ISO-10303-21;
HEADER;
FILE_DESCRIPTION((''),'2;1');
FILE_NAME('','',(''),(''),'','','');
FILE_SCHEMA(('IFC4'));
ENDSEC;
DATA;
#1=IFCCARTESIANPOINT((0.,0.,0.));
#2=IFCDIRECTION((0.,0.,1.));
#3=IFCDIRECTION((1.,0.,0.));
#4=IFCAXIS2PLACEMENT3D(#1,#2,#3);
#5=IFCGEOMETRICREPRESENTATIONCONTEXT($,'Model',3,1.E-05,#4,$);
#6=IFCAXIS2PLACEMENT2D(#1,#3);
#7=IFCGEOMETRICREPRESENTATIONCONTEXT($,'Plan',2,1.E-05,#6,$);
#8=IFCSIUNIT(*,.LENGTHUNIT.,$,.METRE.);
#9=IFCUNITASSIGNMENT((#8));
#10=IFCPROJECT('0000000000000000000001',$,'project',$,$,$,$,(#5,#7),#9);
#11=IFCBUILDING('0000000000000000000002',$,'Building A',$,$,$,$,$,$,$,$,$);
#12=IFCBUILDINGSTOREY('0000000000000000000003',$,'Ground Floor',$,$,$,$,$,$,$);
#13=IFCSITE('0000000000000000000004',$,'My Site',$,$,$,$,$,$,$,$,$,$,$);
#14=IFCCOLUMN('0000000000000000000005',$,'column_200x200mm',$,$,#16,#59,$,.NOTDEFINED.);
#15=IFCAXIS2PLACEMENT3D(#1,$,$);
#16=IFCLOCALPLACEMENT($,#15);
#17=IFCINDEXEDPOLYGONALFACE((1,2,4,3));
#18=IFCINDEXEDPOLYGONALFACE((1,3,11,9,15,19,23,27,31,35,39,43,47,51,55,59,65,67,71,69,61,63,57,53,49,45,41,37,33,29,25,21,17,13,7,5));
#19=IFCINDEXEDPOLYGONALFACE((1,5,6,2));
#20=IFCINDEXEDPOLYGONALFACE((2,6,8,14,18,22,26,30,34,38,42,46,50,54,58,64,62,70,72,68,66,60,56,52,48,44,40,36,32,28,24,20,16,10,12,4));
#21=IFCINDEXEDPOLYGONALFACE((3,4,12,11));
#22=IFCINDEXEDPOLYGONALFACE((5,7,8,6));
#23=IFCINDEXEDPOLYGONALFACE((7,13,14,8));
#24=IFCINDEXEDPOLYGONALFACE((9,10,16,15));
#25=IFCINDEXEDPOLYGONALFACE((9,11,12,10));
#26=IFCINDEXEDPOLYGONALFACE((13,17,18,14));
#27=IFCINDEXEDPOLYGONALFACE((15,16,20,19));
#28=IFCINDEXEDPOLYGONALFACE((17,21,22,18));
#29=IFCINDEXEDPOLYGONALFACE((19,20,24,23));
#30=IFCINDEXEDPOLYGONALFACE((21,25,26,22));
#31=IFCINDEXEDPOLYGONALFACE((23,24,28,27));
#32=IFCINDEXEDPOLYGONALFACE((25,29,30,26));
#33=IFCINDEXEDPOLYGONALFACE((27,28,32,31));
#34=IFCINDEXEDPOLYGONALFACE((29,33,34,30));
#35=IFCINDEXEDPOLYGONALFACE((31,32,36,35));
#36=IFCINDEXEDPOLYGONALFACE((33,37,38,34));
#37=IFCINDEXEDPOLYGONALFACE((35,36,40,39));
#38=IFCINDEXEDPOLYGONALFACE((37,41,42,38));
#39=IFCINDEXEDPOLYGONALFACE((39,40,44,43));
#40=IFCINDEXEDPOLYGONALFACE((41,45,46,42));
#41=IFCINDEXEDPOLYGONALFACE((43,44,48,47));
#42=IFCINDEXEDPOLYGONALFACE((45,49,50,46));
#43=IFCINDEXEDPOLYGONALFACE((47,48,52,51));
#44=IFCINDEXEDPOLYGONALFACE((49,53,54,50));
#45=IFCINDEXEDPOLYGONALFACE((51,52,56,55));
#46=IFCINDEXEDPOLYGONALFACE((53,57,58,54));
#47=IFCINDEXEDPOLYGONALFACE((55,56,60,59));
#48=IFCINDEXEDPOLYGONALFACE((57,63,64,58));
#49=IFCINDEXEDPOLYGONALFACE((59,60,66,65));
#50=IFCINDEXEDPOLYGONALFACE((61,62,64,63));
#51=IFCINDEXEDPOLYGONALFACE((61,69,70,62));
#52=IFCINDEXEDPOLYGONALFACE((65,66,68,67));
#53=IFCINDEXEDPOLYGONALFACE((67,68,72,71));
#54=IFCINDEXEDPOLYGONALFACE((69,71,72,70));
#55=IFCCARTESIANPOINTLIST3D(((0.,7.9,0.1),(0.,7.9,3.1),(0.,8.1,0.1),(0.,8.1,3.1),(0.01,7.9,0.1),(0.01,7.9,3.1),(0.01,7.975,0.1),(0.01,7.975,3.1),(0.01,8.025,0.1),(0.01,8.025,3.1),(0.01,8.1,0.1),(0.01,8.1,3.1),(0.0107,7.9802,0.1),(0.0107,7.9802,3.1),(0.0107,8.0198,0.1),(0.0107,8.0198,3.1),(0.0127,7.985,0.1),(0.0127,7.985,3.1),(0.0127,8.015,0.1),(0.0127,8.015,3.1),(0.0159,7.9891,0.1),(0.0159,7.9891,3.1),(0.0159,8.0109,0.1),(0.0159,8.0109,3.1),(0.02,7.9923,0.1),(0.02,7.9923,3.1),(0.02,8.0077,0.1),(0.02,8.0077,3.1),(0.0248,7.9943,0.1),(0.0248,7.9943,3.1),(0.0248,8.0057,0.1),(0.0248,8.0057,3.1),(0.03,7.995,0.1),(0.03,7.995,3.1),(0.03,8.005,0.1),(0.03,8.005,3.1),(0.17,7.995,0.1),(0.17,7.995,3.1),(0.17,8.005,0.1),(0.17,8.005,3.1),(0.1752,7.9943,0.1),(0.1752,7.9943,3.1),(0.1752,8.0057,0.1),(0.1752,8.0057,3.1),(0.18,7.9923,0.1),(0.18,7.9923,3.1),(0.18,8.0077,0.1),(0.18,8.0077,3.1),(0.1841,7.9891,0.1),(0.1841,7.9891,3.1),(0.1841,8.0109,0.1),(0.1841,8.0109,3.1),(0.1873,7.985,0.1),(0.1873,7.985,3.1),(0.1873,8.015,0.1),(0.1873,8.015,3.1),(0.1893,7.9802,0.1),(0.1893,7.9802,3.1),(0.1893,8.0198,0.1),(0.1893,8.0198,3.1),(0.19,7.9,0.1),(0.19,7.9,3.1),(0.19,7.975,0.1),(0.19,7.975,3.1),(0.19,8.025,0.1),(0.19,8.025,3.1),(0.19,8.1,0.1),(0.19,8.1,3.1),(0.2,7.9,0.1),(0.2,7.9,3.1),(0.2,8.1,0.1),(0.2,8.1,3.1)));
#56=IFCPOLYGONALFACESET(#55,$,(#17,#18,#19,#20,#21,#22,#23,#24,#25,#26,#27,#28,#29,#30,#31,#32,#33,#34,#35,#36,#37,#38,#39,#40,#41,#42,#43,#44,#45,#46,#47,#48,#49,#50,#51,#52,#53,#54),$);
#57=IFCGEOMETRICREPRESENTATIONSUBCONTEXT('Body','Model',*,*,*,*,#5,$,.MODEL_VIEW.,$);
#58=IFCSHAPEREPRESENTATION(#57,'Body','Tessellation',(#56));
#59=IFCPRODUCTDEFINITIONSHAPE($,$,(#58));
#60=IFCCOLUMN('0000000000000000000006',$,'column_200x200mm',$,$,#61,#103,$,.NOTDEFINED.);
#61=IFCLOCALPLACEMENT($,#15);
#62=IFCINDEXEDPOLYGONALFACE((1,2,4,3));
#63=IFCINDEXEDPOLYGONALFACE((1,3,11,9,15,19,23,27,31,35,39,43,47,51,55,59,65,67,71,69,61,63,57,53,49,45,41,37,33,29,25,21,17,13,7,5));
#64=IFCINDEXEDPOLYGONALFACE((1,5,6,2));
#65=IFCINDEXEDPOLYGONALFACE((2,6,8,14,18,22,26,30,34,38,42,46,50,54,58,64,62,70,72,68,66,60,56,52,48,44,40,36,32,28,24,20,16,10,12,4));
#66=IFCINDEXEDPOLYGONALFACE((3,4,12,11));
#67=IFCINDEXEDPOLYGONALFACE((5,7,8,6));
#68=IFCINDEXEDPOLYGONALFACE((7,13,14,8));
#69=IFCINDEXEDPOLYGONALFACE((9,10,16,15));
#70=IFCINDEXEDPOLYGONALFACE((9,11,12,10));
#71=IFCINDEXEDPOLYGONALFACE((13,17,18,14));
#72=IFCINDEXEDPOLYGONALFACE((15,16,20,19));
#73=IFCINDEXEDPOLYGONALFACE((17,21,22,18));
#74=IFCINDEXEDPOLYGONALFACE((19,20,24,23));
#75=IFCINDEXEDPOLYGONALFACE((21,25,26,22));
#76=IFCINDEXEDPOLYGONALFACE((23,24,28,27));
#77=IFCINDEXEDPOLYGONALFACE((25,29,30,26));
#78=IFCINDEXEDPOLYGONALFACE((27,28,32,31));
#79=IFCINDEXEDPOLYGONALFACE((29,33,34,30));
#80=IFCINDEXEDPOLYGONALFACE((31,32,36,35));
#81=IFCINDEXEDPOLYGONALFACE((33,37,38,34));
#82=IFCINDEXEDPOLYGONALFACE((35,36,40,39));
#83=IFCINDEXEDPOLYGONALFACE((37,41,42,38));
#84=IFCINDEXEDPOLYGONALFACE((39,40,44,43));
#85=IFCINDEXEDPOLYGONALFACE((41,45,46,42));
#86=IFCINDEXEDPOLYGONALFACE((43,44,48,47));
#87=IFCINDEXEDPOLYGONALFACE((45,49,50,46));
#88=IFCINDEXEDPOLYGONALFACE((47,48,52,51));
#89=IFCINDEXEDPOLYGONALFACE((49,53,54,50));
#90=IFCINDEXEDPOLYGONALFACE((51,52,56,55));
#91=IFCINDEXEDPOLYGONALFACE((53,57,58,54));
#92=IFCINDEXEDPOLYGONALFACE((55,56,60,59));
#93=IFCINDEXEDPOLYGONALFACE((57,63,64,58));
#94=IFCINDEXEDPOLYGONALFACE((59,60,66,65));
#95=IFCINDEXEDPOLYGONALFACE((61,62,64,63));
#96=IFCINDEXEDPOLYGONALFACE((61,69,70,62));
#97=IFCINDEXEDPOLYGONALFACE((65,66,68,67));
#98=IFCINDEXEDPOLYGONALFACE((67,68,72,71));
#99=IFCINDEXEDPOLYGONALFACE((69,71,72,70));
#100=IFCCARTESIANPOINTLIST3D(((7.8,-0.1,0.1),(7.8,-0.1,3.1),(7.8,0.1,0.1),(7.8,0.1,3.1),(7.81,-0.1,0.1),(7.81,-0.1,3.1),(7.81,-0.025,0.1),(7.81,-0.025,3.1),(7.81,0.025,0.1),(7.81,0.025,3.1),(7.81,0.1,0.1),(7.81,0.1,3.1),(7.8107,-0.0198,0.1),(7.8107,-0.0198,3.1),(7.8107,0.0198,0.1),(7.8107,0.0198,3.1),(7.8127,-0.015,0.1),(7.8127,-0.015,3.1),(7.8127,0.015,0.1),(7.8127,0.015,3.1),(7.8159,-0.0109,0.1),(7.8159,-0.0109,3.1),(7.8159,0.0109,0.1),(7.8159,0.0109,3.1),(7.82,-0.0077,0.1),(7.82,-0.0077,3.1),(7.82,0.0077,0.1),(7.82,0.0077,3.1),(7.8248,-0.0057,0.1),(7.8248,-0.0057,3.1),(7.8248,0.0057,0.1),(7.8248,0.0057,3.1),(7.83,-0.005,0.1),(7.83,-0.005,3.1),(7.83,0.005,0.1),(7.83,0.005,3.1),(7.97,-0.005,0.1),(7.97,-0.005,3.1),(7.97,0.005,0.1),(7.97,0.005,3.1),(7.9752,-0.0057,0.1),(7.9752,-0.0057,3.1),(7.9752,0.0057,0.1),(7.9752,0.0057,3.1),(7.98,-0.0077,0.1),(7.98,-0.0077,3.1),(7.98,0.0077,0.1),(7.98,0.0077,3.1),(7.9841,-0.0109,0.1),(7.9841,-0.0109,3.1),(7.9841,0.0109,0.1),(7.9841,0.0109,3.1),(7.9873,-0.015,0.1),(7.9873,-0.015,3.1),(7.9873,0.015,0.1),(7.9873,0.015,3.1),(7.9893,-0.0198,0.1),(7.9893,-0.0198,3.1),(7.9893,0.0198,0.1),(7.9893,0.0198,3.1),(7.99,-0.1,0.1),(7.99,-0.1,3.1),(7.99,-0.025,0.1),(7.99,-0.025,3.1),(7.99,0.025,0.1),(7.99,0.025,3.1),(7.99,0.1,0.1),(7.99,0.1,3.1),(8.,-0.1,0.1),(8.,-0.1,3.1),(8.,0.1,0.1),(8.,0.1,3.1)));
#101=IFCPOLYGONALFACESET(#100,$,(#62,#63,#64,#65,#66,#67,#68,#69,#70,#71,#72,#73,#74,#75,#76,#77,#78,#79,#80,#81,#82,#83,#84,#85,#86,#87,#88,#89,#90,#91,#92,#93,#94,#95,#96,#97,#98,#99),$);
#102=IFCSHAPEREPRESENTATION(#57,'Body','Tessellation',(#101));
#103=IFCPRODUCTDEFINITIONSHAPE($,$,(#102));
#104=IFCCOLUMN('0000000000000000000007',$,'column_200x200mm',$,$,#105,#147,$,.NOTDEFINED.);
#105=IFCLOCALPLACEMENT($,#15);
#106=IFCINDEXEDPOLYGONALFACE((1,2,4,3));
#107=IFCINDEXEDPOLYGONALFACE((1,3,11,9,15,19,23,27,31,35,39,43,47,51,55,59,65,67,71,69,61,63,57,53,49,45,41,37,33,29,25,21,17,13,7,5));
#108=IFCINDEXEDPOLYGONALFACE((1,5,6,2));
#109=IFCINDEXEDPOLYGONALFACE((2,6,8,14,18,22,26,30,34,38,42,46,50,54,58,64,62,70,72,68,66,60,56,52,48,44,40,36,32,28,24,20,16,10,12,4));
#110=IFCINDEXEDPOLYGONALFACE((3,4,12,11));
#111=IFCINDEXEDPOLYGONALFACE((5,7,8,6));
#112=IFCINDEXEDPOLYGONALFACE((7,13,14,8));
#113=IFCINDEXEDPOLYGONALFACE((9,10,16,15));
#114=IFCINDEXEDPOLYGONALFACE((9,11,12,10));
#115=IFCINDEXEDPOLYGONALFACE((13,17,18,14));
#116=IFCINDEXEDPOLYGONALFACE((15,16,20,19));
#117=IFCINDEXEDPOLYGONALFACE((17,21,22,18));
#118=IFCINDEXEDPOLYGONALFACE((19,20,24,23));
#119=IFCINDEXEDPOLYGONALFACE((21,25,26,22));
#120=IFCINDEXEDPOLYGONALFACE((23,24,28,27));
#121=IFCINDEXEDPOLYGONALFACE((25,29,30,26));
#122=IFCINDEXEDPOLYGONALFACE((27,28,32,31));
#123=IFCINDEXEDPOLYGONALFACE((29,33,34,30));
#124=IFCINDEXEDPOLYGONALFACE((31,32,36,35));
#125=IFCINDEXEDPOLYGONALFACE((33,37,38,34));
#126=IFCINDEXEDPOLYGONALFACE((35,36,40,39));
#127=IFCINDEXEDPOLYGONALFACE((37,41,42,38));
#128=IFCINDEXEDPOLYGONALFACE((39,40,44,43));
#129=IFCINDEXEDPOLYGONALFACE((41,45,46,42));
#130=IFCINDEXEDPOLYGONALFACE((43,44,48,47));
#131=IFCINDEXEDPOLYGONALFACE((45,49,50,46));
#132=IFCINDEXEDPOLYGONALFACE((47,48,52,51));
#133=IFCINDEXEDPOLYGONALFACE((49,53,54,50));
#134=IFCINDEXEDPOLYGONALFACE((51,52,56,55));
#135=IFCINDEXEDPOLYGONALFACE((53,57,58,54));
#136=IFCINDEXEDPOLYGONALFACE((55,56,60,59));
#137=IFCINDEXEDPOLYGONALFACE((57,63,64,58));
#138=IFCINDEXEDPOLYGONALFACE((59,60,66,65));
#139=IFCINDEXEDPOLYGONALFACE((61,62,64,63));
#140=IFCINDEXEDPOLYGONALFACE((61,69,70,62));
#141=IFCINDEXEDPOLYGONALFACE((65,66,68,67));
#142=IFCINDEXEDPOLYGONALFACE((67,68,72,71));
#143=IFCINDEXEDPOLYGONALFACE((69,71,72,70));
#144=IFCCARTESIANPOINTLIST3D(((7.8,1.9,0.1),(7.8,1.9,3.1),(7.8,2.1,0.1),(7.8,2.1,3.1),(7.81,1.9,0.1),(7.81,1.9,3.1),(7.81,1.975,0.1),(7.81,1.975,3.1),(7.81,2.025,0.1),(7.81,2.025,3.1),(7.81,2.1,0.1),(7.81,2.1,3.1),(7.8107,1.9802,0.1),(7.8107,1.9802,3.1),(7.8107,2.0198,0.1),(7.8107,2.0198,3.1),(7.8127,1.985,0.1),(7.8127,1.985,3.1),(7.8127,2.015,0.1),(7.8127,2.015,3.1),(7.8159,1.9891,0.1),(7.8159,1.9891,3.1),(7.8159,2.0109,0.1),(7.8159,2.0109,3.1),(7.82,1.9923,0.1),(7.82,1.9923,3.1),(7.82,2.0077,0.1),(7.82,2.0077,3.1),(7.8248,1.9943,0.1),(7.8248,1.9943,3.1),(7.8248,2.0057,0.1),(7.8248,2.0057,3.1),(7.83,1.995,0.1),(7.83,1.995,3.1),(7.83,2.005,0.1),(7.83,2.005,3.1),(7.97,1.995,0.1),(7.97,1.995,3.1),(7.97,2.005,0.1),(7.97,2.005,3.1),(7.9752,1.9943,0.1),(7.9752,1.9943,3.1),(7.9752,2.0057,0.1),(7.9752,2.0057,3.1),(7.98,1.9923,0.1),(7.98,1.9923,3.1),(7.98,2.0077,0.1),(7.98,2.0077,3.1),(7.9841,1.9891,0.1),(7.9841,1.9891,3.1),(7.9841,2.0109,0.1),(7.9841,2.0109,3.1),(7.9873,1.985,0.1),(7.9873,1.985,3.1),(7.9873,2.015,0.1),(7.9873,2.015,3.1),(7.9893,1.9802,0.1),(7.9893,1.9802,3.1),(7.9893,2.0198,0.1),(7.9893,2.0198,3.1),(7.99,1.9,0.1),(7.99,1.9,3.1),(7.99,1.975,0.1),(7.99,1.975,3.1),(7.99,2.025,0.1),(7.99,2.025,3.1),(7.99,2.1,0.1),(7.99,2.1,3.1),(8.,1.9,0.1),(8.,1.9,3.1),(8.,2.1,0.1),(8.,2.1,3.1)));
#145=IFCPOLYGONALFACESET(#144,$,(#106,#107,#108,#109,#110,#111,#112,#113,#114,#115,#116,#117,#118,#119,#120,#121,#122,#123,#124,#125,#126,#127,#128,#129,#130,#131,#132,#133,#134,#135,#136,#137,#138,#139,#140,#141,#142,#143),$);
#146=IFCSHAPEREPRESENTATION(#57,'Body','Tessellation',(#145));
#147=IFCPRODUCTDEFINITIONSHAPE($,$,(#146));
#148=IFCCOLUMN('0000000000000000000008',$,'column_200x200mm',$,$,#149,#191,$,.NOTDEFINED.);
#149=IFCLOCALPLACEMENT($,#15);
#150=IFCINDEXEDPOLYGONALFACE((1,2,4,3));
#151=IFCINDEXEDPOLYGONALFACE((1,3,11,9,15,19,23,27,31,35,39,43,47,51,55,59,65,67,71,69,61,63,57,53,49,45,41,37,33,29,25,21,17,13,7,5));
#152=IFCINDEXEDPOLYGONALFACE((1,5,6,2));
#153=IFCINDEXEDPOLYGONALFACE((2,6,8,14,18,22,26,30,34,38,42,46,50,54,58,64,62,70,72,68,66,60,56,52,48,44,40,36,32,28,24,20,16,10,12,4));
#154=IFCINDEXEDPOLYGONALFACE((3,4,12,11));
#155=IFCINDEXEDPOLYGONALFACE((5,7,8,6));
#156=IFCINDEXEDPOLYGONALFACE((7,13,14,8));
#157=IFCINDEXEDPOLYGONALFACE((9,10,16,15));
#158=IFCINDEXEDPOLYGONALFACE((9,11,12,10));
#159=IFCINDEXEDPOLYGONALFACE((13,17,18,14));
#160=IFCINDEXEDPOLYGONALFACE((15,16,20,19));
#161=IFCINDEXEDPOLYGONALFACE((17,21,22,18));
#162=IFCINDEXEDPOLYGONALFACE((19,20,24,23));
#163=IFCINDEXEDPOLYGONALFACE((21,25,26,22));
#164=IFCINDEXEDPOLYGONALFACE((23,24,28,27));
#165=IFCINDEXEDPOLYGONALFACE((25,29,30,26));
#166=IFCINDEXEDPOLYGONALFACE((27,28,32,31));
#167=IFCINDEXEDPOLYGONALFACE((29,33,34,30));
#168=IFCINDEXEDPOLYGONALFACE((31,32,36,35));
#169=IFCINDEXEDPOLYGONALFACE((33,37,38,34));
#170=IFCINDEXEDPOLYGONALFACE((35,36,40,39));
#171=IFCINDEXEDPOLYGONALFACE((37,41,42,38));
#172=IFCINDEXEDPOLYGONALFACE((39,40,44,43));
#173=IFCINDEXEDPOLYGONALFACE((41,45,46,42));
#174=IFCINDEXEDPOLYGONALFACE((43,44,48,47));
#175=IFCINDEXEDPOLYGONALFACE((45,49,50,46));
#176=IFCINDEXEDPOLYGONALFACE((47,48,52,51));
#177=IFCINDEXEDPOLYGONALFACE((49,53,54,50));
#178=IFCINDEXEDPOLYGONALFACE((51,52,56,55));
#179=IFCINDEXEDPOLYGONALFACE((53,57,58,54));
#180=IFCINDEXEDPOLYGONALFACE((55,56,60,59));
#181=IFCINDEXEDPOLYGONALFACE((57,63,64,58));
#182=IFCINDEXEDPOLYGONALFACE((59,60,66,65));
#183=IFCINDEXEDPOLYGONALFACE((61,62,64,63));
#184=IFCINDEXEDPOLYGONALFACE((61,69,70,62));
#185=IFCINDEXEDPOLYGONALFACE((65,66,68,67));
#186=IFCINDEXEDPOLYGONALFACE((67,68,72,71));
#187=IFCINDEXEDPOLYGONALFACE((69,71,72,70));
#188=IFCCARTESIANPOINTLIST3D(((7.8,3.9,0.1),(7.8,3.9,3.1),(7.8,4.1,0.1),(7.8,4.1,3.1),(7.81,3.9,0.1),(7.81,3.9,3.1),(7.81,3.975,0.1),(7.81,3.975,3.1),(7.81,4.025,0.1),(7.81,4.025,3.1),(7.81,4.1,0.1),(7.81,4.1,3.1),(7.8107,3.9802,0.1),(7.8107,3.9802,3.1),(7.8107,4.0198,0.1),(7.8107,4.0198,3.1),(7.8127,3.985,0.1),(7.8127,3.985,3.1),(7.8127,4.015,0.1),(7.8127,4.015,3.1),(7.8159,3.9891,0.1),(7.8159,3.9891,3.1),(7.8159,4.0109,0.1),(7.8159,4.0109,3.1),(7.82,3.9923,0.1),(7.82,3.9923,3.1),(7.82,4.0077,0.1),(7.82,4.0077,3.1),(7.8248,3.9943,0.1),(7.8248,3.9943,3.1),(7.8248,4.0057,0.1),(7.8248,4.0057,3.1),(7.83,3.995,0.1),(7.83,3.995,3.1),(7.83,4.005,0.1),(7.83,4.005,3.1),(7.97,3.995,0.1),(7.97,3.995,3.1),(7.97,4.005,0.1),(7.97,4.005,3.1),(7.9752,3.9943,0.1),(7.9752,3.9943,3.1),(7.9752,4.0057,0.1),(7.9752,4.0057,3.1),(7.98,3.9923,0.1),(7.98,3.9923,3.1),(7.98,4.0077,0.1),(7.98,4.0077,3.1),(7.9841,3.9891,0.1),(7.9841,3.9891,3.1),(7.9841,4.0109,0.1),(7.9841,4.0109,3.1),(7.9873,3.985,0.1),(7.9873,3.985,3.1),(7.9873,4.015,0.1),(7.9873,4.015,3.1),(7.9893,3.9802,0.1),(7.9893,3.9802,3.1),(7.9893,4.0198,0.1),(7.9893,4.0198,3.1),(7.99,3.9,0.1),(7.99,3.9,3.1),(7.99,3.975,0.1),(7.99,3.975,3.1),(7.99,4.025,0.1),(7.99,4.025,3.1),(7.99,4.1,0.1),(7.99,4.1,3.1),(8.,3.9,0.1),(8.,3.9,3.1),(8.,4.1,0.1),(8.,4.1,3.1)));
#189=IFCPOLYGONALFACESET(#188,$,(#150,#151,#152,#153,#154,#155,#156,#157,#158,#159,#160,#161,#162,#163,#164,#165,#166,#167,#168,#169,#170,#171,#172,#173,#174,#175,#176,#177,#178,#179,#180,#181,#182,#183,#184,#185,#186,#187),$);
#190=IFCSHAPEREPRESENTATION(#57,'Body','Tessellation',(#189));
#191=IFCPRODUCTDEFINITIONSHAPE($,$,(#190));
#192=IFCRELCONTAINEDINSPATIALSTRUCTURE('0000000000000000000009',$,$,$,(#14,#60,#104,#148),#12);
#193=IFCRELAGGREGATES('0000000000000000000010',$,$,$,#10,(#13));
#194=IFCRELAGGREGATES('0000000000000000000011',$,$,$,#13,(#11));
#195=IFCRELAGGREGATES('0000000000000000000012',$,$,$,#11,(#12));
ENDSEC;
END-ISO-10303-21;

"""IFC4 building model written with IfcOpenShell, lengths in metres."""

from ifc_helpers import new_model, entity, si_unit, frame, frame_2d, origin_with_axes, place, context, subcontext, project, spatial, extrude, element, save


model = new_model("IFC4")

# Units and contexts
model_context = context("Model", 3, precision=1e-05, world=origin_with_axes())
plan_context = context("Plan", 2, precision=1e-05, world=frame_2d((0.0, 0.0, 0.0), x_axis=(1.0, 0.0, 0.0)))
body_context = subcontext(model_context, "Body", "Model", "MODEL_VIEW")
ifc_project = project(units=[si_unit("LENGTHUNIT", "METRE")], contexts=[model_context, plan_context])

# Site, building, storey
site = spatial("IfcSite", under=ifc_project, Name="My Site")
building = spatial("IfcBuilding", under=site, Name="Building A")
storey = spatial("IfcBuildingStorey", under=building, Name="Ground Floor")

# Columns
for number, where, z_axis, x_axis, name in (
    (1, (0.1, 8.0, 0.1), (0.0, 0.0, 1.0), (0.0, 1.0, 0.0), "column_200x200mm"),
    (2, (7.9, 0.0, 0.1), (0.0, 0.0, 1.0), (0.0, 1.0, 0.0), "column_200x200mm"),
    (3, (7.9, 2.0, 0.1), (0.0, 0.0, 1.0), (0.0, 1.0, 0.0), "column_200x200mm"),
    (4, (7.9, 4.0, 0.1), (0.0, 0.0, 1.0), (0.0, 1.0, 0.0), "column_200x200mm"),
):
    element("IfcColumn", number, at=place(None, frame(where, z_axis=z_axis, x_axis=x_axis)), inside=storey, Name=name, PredefinedType="NOTDEFINED", context=body_context, shape_type="SweptSolid", body=[
        extrude(entity("IfcIShapeProfileDef", None, None, None, 0.2, 0.2, 0.01, 0.01, 0.02), origin_with_axes(), (0.0, 0.0, 1.0), 3.0),
    ])

save(model, "model.ifc")
